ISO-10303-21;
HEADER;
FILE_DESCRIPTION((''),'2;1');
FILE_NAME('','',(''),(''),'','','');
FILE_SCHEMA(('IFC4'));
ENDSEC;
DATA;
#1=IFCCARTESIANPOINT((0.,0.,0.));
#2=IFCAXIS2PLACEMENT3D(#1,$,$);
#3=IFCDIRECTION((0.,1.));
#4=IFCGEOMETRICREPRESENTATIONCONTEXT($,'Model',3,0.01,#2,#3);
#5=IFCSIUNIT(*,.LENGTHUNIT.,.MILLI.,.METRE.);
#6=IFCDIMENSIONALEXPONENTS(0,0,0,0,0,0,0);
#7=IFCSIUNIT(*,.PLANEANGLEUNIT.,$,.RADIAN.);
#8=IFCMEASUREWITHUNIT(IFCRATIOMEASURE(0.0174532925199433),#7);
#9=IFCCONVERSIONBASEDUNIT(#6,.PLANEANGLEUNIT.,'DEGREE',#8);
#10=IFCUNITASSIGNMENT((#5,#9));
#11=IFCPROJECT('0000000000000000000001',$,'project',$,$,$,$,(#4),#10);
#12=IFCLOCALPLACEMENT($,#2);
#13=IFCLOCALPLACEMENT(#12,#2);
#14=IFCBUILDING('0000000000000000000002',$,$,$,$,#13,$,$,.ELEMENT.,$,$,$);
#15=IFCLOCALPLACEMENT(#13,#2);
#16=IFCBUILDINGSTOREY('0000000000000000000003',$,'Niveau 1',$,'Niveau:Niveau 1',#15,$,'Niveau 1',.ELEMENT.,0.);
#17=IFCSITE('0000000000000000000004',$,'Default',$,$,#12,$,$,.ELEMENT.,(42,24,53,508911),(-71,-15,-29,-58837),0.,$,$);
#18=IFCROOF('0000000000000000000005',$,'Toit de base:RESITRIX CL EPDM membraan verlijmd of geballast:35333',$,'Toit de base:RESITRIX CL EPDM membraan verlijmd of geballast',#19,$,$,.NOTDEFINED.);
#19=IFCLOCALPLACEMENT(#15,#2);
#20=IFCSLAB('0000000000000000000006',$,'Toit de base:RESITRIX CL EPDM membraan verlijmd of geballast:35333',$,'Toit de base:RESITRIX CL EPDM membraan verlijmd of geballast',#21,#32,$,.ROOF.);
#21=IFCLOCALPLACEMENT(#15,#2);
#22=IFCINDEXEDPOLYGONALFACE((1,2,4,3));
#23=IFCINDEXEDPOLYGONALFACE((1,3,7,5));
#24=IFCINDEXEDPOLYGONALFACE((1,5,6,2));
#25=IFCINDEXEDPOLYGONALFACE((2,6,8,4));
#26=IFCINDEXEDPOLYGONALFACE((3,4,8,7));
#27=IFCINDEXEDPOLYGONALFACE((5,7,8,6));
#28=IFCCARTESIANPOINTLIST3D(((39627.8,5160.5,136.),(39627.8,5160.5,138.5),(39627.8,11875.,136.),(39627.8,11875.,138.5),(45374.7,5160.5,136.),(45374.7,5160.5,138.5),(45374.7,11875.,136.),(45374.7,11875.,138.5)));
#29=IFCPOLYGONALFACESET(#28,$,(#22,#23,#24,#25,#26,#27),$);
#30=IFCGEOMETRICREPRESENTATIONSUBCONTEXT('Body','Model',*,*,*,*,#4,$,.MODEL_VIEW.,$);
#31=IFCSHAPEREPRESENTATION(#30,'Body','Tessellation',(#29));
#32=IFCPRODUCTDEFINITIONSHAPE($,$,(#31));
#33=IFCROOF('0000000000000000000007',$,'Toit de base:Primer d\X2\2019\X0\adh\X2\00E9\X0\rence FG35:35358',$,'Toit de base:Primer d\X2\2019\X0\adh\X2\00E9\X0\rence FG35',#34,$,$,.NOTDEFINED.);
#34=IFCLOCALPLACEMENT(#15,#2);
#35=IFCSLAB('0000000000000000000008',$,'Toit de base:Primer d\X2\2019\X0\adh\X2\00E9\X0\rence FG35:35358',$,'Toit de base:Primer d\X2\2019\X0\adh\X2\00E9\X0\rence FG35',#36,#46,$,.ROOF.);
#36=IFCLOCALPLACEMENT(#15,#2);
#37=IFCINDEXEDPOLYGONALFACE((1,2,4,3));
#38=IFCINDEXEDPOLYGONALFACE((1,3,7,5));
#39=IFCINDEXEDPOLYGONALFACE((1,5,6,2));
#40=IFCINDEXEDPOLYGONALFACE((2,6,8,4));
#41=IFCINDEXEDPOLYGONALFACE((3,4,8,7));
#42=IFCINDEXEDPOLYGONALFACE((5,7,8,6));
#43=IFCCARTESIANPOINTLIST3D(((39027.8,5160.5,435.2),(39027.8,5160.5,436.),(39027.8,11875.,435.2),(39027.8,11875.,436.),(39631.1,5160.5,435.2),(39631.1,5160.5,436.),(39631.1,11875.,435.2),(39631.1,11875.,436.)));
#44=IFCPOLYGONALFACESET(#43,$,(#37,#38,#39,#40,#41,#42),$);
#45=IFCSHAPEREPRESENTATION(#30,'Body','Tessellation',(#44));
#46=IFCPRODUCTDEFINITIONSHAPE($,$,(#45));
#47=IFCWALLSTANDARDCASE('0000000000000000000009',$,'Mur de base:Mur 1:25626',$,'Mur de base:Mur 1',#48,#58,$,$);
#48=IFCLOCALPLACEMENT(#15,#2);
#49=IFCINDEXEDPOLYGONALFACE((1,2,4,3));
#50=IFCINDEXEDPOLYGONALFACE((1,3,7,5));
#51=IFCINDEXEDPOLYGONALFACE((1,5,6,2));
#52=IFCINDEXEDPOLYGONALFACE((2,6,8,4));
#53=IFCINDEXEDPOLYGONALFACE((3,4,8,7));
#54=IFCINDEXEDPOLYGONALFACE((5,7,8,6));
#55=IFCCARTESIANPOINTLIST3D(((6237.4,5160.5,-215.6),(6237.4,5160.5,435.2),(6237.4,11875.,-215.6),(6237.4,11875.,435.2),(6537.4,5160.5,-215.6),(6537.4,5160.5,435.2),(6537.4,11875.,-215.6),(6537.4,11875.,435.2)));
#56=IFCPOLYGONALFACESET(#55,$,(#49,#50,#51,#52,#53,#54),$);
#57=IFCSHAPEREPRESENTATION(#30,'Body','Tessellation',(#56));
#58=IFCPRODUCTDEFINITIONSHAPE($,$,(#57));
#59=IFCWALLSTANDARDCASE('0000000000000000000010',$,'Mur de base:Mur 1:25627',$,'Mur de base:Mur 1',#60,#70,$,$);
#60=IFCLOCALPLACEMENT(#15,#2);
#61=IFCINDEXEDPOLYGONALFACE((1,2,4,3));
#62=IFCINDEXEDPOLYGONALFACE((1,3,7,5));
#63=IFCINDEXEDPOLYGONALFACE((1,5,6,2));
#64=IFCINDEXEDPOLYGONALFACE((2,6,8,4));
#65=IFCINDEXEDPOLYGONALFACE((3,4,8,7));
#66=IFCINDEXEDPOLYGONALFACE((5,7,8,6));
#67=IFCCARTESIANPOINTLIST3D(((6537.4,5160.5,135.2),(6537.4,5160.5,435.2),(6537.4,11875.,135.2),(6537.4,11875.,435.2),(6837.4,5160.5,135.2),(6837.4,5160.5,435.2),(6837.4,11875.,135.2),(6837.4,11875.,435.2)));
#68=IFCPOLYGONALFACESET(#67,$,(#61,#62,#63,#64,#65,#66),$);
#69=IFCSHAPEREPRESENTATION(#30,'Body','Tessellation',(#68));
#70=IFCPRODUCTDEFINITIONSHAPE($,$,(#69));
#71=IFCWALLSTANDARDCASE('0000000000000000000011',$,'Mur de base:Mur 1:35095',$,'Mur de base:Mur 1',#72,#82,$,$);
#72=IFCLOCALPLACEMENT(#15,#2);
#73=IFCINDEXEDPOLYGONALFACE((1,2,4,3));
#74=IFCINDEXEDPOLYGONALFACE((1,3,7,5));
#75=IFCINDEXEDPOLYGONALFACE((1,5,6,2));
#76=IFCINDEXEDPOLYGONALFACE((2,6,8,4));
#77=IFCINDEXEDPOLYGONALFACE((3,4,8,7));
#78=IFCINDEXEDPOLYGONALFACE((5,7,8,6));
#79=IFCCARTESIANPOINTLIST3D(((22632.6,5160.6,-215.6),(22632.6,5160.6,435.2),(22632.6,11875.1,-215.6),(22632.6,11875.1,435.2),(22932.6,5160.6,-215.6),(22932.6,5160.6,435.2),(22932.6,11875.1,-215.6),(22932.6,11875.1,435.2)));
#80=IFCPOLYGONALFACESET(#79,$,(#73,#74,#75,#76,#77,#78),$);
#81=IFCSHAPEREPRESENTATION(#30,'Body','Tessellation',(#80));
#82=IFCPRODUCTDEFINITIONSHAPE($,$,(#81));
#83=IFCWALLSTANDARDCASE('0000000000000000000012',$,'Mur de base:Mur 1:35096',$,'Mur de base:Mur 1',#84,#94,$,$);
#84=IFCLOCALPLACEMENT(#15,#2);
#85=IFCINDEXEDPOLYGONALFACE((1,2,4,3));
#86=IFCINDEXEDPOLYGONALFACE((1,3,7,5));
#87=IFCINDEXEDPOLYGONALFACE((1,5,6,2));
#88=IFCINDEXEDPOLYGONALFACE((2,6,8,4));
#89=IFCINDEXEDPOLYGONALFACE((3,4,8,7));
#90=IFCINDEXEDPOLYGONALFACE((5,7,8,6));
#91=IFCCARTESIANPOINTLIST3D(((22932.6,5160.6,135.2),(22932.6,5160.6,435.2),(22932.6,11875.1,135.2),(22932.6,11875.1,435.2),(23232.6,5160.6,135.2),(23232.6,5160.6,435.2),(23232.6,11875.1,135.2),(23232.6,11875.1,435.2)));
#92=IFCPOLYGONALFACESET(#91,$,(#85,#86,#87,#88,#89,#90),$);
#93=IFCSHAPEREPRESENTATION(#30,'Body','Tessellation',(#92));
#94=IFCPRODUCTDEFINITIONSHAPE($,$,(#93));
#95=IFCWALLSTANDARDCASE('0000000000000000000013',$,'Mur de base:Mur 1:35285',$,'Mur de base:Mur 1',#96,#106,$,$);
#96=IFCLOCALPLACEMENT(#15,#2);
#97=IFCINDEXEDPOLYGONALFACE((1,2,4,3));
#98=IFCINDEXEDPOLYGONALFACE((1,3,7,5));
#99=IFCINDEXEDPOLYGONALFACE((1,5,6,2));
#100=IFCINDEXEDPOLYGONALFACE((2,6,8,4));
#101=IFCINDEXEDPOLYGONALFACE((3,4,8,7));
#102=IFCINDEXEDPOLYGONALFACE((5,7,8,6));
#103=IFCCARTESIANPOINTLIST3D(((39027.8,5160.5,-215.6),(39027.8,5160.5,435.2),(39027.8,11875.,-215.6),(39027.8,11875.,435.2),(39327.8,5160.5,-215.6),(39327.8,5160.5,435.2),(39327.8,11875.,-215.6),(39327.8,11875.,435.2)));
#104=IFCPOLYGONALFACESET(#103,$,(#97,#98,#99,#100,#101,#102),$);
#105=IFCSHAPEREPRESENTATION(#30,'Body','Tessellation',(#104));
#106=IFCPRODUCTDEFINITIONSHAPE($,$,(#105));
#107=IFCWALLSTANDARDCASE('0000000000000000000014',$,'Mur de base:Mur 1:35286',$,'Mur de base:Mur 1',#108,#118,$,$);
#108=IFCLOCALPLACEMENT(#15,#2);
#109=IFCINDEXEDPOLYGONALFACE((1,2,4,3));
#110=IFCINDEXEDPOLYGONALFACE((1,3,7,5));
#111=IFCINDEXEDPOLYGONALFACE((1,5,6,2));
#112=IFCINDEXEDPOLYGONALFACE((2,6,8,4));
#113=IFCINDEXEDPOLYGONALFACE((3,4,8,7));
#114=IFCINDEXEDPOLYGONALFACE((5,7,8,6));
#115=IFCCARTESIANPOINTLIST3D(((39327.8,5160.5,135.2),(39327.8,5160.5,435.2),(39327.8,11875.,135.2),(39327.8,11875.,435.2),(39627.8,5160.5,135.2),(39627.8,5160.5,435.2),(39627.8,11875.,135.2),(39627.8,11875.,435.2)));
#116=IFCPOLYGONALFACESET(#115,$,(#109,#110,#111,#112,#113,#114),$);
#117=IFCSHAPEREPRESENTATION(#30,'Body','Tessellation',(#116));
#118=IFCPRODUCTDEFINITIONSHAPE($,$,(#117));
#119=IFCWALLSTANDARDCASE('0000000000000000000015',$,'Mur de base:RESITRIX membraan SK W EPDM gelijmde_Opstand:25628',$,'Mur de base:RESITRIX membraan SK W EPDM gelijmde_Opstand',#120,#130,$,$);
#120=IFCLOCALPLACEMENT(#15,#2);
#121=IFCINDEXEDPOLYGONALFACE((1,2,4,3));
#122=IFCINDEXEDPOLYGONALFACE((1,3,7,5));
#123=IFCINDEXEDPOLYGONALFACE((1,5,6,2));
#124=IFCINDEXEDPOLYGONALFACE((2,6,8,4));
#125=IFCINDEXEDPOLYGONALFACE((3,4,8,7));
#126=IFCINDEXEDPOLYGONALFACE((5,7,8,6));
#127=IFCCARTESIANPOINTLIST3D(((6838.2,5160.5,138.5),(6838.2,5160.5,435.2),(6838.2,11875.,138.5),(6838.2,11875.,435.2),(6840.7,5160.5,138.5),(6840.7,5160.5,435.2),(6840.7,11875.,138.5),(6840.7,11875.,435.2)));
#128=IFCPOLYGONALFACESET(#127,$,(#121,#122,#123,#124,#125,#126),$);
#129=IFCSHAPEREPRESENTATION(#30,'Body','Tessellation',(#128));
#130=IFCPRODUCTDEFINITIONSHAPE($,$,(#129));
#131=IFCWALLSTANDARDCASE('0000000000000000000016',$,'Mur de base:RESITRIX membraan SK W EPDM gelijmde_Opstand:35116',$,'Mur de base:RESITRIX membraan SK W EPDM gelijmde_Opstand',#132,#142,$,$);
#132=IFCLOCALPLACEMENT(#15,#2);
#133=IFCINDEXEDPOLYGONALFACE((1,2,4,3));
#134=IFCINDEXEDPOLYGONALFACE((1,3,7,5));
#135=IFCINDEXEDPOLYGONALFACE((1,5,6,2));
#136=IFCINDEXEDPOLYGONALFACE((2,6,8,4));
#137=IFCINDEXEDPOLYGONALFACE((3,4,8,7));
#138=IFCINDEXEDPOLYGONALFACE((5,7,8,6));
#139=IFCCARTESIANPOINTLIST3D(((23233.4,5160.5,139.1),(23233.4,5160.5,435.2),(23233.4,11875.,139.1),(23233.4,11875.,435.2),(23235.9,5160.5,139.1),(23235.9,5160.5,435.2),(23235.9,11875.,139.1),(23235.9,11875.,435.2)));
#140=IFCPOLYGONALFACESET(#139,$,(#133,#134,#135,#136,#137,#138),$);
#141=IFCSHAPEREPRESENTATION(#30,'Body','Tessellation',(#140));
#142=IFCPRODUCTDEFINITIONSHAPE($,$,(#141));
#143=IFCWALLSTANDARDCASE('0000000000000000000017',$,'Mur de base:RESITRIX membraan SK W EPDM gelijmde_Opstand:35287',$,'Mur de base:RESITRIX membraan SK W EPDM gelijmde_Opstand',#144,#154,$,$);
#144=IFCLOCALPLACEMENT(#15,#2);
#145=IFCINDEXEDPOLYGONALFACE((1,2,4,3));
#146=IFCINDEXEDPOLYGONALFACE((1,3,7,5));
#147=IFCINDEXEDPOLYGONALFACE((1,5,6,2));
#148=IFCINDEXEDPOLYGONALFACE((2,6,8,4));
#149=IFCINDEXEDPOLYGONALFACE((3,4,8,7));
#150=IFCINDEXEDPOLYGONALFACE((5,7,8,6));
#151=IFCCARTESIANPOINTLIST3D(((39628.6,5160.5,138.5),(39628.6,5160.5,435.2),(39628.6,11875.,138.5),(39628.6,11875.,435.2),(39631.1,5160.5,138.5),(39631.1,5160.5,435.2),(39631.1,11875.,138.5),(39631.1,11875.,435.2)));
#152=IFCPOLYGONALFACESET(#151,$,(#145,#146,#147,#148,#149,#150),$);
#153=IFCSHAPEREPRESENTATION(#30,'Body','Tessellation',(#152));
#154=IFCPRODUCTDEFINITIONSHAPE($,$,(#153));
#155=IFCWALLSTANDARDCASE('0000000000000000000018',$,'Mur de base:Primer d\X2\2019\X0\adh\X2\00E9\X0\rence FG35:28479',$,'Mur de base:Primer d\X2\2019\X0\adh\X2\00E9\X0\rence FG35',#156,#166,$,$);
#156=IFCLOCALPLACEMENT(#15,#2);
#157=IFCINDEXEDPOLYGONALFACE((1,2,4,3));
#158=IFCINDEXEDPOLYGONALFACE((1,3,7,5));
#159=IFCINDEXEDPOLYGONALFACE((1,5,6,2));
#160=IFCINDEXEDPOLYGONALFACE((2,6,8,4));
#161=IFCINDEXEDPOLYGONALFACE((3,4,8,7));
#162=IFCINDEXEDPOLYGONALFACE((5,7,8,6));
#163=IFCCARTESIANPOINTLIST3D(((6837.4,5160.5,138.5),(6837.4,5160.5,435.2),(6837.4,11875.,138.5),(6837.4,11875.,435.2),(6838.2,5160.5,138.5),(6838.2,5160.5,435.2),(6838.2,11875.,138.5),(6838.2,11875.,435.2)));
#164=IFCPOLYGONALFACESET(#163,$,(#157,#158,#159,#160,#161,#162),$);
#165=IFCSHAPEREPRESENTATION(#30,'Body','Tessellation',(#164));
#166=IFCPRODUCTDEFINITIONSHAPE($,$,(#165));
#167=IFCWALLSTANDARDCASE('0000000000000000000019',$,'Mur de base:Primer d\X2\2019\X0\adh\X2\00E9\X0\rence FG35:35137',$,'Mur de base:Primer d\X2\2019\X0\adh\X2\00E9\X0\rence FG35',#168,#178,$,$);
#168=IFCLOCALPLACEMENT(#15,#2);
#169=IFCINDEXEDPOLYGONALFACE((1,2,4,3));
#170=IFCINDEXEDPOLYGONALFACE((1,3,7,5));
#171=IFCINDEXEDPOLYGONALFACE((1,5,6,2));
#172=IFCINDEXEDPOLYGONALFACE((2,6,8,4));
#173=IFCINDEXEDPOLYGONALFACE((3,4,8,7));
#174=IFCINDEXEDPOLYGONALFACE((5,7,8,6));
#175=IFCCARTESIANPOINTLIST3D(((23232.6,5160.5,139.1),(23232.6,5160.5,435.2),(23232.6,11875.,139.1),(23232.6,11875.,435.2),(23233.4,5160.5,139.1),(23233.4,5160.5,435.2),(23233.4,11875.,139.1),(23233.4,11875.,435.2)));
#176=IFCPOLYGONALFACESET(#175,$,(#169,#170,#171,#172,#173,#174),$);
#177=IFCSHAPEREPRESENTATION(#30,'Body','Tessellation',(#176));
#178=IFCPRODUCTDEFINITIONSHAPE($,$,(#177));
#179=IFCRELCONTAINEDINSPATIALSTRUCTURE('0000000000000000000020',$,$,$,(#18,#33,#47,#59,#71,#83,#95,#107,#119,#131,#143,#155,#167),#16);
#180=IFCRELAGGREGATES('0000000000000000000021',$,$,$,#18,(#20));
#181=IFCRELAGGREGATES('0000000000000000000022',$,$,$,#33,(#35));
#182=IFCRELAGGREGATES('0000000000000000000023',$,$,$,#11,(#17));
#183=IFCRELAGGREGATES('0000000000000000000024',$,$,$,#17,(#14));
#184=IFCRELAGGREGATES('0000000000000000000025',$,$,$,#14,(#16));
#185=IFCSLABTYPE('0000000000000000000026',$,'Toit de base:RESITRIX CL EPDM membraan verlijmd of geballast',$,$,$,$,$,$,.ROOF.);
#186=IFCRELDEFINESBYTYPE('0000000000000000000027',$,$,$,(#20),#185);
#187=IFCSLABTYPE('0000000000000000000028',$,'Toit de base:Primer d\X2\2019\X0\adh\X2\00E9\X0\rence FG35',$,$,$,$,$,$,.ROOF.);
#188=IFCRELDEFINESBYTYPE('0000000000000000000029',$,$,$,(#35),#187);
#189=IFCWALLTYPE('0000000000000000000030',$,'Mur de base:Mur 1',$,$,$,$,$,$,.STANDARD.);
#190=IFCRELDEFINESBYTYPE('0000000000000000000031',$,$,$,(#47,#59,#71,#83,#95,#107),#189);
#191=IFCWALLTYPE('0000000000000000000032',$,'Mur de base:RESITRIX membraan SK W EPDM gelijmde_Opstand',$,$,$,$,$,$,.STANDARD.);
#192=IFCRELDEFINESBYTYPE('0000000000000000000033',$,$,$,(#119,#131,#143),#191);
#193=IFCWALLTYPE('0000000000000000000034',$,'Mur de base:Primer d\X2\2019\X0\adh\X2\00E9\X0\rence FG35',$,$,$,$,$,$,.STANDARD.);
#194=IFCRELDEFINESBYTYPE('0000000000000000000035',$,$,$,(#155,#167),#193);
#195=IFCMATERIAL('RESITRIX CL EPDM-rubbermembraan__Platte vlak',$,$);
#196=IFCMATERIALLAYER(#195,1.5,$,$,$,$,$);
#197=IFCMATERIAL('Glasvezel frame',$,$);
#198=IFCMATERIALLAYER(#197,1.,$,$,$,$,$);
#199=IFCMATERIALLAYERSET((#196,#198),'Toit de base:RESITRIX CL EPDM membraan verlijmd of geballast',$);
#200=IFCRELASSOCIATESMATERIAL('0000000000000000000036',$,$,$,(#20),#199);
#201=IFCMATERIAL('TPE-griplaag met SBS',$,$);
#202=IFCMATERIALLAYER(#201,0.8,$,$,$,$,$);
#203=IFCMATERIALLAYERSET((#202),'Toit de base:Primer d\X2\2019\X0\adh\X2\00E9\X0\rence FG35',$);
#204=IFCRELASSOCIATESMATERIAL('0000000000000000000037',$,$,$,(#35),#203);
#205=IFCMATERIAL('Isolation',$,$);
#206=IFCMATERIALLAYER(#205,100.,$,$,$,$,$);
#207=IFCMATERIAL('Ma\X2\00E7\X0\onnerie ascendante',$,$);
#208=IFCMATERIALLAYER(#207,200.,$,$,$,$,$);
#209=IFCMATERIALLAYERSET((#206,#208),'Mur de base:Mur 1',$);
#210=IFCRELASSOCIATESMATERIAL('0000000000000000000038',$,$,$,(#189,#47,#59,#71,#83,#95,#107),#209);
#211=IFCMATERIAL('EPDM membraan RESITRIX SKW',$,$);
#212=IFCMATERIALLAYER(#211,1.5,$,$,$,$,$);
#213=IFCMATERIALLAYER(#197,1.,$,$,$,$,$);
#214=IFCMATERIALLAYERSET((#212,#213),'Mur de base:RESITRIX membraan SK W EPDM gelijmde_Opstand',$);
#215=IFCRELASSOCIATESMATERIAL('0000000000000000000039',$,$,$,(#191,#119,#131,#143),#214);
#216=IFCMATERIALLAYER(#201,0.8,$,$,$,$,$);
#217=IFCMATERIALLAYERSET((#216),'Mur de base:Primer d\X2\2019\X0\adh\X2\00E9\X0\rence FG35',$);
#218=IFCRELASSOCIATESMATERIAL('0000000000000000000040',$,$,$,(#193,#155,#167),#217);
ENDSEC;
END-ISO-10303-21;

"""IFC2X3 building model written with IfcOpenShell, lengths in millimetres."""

from ifc_helpers import new_model, entity, si_unit, converted_unit, direction, frame, frame_2d, origin, place, context, subcontext, project, spatial, rectangle, extrude, clip, halfspace, material, layer, layer_set, layer_usage, type_object, element, aggregate, save


model = new_model("IFC2X3")

# Units and contexts
model_context = context("Model", 3, precision=0.01, world=origin(), true_north=direction((0.0, 1.0)))
body_context = subcontext(model_context, "Body", "Model", "MODEL_VIEW")
ifc_project = project(units=[si_unit("LENGTHUNIT", "METRE", prefix="MILLI"), converted_unit("PLANEANGLEUNIT", "DEGREE", entity("IfcRatioMeasure", 0.0174532925199433), si_unit("PLANEANGLEUNIT", "RADIAN"), dimensions=[0, 0, 0, 0, 0, 0, 0])], contexts=[model_context])

# Site, building, storey
site_placement = place(None, origin())
site = spatial("IfcSite", under=ifc_project, at=site_placement, Name="Default", CompositionType="ELEMENT", RefLatitude=(42, 24, 53, 508911), RefLongitude=(-71, -15, -29, -58837), RefElevation=0.0)
building_placement = place(site_placement, origin())
building = spatial("IfcBuilding", under=site, at=building_placement, CompositionType="ELEMENT")
storey_placement = place(building_placement, origin())
storey = spatial("IfcBuildingStorey", under=building, at=storey_placement, Name="Niveau 1", ObjectType="Niveau:Niveau 1", LongName="Niveau 1", CompositionType="ELEMENT", Elevation=0.0)

# Roofs, slabs
ifc_material_1 = material(Name="TPE-griplaag met SBS")
ifc_layer_1 = layer(ifc_material_1, 0.8)
ifc_layer_set_1 = layer_set([ifc_layer_1], Name="Toit de base:Primer d’adhérence FG35")
ifc_material_2 = material(Name="Isolation")
ifc_material_3 = material(Name="EPDM membraan RESITRIX SKW")
ifc_material_4 = material(Name="Glasvezel frame")
roof_1_placement = place(storey_placement, frame((39627.8, 5160.5, 136.0)))
roof_1 = element("IfcRoof", 1, at=roof_1_placement, inside=storey, Name="Toit de base:RESITRIX CL EPDM membraan verlijmd of geballast:35333", ObjectType="Toit de base:RESITRIX CL EPDM membraan verlijmd of geballast", ShapeType="NOTDEFINED")
ifc_material_5 = material(Name="RESITRIX CL EPDM-rubbermembraan__Platte vlak")
ifc_layer_2 = layer(ifc_material_5, 1.5)
ifc_layer_3 = layer(ifc_material_4, 1.0)
ifc_layer_set_2 = layer_set([ifc_layer_2, ifc_layer_3], Name="Toit de base:RESITRIX CL EPDM membraan verlijmd of geballast")
slab_type_1 = type_object("IfcSlabType", Name="Toit de base:RESITRIX CL EPDM membraan verlijmd of geballast", PredefinedType="ROOF")
slab_1_placement = place(roof_1_placement, origin())
slab_1 = element("IfcSlab", 2, at=slab_1_placement, type_object=slab_type_1, material=ifc_layer_set_2, Name="Toit de base:RESITRIX CL EPDM membraan verlijmd of geballast:35333", ObjectType="Toit de base:RESITRIX CL EPDM membraan verlijmd of geballast", PredefinedType="ROOF", context=body_context, shape_type="SweptSolid", body=[
    extrude(rectangle(XDim=6714.5, YDim=5747.0, at=frame_2d((0.0, 0.0), x_axis=(0.0, 1.0))), frame((2873.5, 3357.2, 0.0)), (0.0, 0.0, 1.0), 2.5),
])
aggregate(roof_1, [slab_1])
roof_2_placement = place(storey_placement, frame((39027.8, 5160.5, 435.2)))
roof_2 = element("IfcRoof", 3, at=roof_2_placement, inside=storey, Name="Toit de base:Primer d’adhérence FG35:35358", ObjectType="Toit de base:Primer d’adhérence FG35", ShapeType="NOTDEFINED")
slab_type_2 = type_object("IfcSlabType", Name="Toit de base:Primer d’adhérence FG35", PredefinedType="ROOF")
slab_2_placement = place(roof_2_placement, origin())
slab_2 = element("IfcSlab", 4, at=slab_2_placement, type_object=slab_type_2, material=ifc_layer_set_1, Name="Toit de base:Primer d’adhérence FG35:35358", ObjectType="Toit de base:Primer d’adhérence FG35", PredefinedType="ROOF", context=body_context, shape_type="SweptSolid", body=[
    extrude(rectangle(XDim=6714.5, YDim=603.3, at=frame_2d((0.0, 0.0), x_axis=(0.0, 1.0))), frame((301.7, 3357.2, 0.0)), (0.0, 0.0, 1.0), 0.8),
])
aggregate(roof_2, [slab_2])

# Walls
ifc_layer_4 = layer(ifc_material_2, 100.0)
ifc_material_6 = material(Name="Maçonnerie ascendante")
ifc_layer_5 = layer(ifc_material_6, 200.0)
ifc_layer_set_3 = layer_set([ifc_layer_4, ifc_layer_5], Name="Mur de base:Mur 1")
ifc_layer_usage_1 = layer_usage(ifc_layer_set_3, "AXIS2", "NEGATIVE", 150.0)
wall_type_1 = type_object("IfcWallType", Name="Mur de base:Mur 1", PredefinedType="STANDARD", material=ifc_layer_set_3)
wall_1_placement = place(storey_placement, frame((6387.4, 11875.0, -215.6), z_axis=(0.0, 0.0, 1.0), x_axis=(0.0, -1.0, 0.0)))
element("IfcWallStandardCase", 5, at=wall_1_placement, inside=storey, type_object=wall_type_1, material=ifc_layer_usage_1, Name="Mur de base:Mur 1:25626", ObjectType="Mur de base:Mur 1", context=body_context, shape_type="SweptSolid", body=[
    extrude(rectangle(XDim=6714.5, YDim=300.0, at=frame_2d((3357.2, 0.0), x_axis=(-1.0, 0.0))), origin(), (0.0, 0.0, 1.0), 650.8),
])
ifc_layer_usage_2 = layer_usage(ifc_layer_set_3, "AXIS2", "NEGATIVE", 150.0)
wall_2_placement = place(storey_placement, frame((6687.4, 11875.0, 135.2), z_axis=(0.0, 0.0, 1.0), x_axis=(0.0, -1.0, 0.0)))
element("IfcWallStandardCase", 6, at=wall_2_placement, inside=storey, type_object=wall_type_1, material=ifc_layer_usage_2, Name="Mur de base:Mur 1:25627", ObjectType="Mur de base:Mur 1", context=body_context, shape_type="Clipping", body=[
    clip(extrude(rectangle(XDim=6714.5, YDim=300.0, at=frame_2d((3357.2, 0.0), x_axis=(-1.0, 0.0))), origin(), (0.0, 0.0, 1.0), 300.0), halfspace(frame((6714.5, -150.0, 0.0), z_axis=(0.0, 0.0, -1.0), x_axis=(0.0, 1.0, 0.0)), False)),
])
ifc_layer_usage_3 = layer_usage(ifc_layer_set_3, "AXIS2", "NEGATIVE", 150.0)
wall_3_placement = place(storey_placement, frame((22782.6, 11875.1, -215.6), z_axis=(0.0, 0.0, 1.0), x_axis=(0.0, -1.0, 0.0)))
element("IfcWallStandardCase", 7, at=wall_3_placement, inside=storey, type_object=wall_type_1, material=ifc_layer_usage_3, Name="Mur de base:Mur 1:35095", ObjectType="Mur de base:Mur 1", context=body_context, shape_type="SweptSolid", body=[
    extrude(rectangle(XDim=6714.5, YDim=300.0, at=frame_2d((3357.2, 0.0), x_axis=(-1.0, 0.0))), origin(), (0.0, 0.0, 1.0), 650.8),
])
ifc_layer_usage_4 = layer_usage(ifc_layer_set_3, "AXIS2", "NEGATIVE", 150.0)
wall_4_placement = place(storey_placement, frame((23082.6, 11875.1, 135.2), z_axis=(0.0, 0.0, 1.0), x_axis=(0.0, -1.0, 0.0)))
element("IfcWallStandardCase", 8, at=wall_4_placement, inside=storey, type_object=wall_type_1, material=ifc_layer_usage_4, Name="Mur de base:Mur 1:35096", ObjectType="Mur de base:Mur 1", context=body_context, shape_type="Clipping", body=[
    clip(extrude(rectangle(XDim=6714.5, YDim=300.0, at=frame_2d((3357.2, 0.0), x_axis=(-1.0, 0.0))), origin(), (0.0, 0.0, 1.0), 300.0), halfspace(frame((6714.5, -150.0, 0.0), z_axis=(0.0, 0.0, -1.0), x_axis=(0.0, 1.0, 0.0)), False)),
])
ifc_layer_usage_5 = layer_usage(ifc_layer_set_3, "AXIS2", "NEGATIVE", 150.0)
wall_5_placement = place(storey_placement, frame((39177.8, 11875.0, -215.6), z_axis=(0.0, 0.0, 1.0), x_axis=(0.0, -1.0, 0.0)))
element("IfcWallStandardCase", 9, at=wall_5_placement, inside=storey, type_object=wall_type_1, material=ifc_layer_usage_5, Name="Mur de base:Mur 1:35285", ObjectType="Mur de base:Mur 1", context=body_context, shape_type="SweptSolid", body=[
    extrude(rectangle(XDim=6714.5, YDim=300.0, at=frame_2d((3357.2, 0.0), x_axis=(-1.0, 0.0))), origin(), (0.0, 0.0, 1.0), 650.8),
])
ifc_layer_usage_6 = layer_usage(ifc_layer_set_3, "AXIS2", "NEGATIVE", 150.0)
wall_6_placement = place(storey_placement, frame((39477.8, 11875.0, 135.2), z_axis=(0.0, 0.0, 1.0), x_axis=(0.0, -1.0, 0.0)))
element("IfcWallStandardCase", 10, at=wall_6_placement, inside=storey, type_object=wall_type_1, material=ifc_layer_usage_6, Name="Mur de base:Mur 1:35286", ObjectType="Mur de base:Mur 1", context=body_context, shape_type="Clipping", body=[
    clip(extrude(rectangle(XDim=6714.5, YDim=300.0, at=frame_2d((3357.2, 0.0), x_axis=(-1.0, 0.0))), origin(), (0.0, 0.0, 1.0), 300.0), halfspace(frame((6714.5, -150.0, 0.0), z_axis=(0.0, 0.0, -1.0), x_axis=(0.0, 1.0, 0.0)), False)),
])
ifc_layer_6 = layer(ifc_material_3, 1.5)
ifc_layer_7 = layer(ifc_material_4, 1.0)
ifc_layer_set_4 = layer_set([ifc_layer_6, ifc_layer_7], Name="Mur de base:RESITRIX membraan SK W EPDM gelijmde_Opstand")
ifc_layer_usage_7 = layer_usage(ifc_layer_set_4, "AXIS2", "NEGATIVE", 1.2)
wall_type_2 = type_object("IfcWallType", Name="Mur de base:RESITRIX membraan SK W EPDM gelijmde_Opstand", PredefinedType="STANDARD", material=ifc_layer_set_4)
wall_7_placement = place(storey_placement, frame((6839.4, 11875.0, 138.5), z_axis=(0.0, 0.0, 1.0), x_axis=(0.0, -1.0, 0.0)))
element("IfcWallStandardCase", 11, at=wall_7_placement, inside=storey, type_object=wall_type_2, material=ifc_layer_usage_7, Name="Mur de base:RESITRIX membraan SK W EPDM gelijmde_Opstand:25628", ObjectType="Mur de base:RESITRIX membraan SK W EPDM gelijmde_Opstand", context=body_context, shape_type="SweptSolid", body=[
    extrude(rectangle(XDim=6714.5, YDim=2.5, at=frame_2d((3357.2, 0.0), x_axis=(-1.0, 0.0))), origin(), (0.0, 0.0, 1.0), 296.7),
])
ifc_layer_usage_8 = layer_usage(ifc_layer_set_4, "AXIS2", "NEGATIVE", 1.2)
wall_8_placement = place(storey_placement, frame((23234.6, 11875.0, 139.1), z_axis=(0.0, 0.0, 1.0), x_axis=(0.0, -1.0, 0.0)))
element("IfcWallStandardCase", 12, at=wall_8_placement, inside=storey, type_object=wall_type_2, material=ifc_layer_usage_8, Name="Mur de base:RESITRIX membraan SK W EPDM gelijmde_Opstand:35116", ObjectType="Mur de base:RESITRIX membraan SK W EPDM gelijmde_Opstand", context=body_context, shape_type="SweptSolid", body=[
    extrude(rectangle(XDim=6714.5, YDim=2.5, at=frame_2d((3357.2, 0.0), x_axis=(-1.0, 0.0))), origin(), (0.0, 0.0, 1.0), 296.1),
])
ifc_layer_usage_9 = layer_usage(ifc_layer_set_4, "AXIS2", "NEGATIVE", 1.2)
wall_9_placement = place(storey_placement, frame((39629.8, 11875.0, 138.5), z_axis=(0.0, 0.0, 1.0), x_axis=(0.0, -1.0, 0.0)))
element("IfcWallStandardCase", 13, at=wall_9_placement, inside=storey, type_object=wall_type_2, material=ifc_layer_usage_9, Name="Mur de base:RESITRIX membraan SK W EPDM gelijmde_Opstand:35287", ObjectType="Mur de base:RESITRIX membraan SK W EPDM gelijmde_Opstand", context=body_context, shape_type="SweptSolid", body=[
    extrude(rectangle(XDim=6714.5, YDim=2.5, at=frame_2d((3357.2, 0.0), x_axis=(-1.0, 0.0))), origin(), (0.0, 0.0, 1.0), 296.7),
])
ifc_layer_8 = layer(ifc_material_1, 0.8)
ifc_layer_set_5 = layer_set([ifc_layer_8], Name="Mur de base:Primer d’adhérence FG35")
ifc_layer_usage_10 = layer_usage(ifc_layer_set_5, "AXIS2", "NEGATIVE", 0.4)
wall_type_3 = type_object("IfcWallType", Name="Mur de base:Primer d’adhérence FG35", PredefinedType="STANDARD", material=ifc_layer_set_5)
wall_10_placement = place(storey_placement, frame((6837.8, 11875.0, 138.5), z_axis=(0.0, 0.0, 1.0), x_axis=(0.0, -1.0, 0.0)))
element("IfcWallStandardCase", 14, at=wall_10_placement, inside=storey, type_object=wall_type_3, material=ifc_layer_usage_10, Name="Mur de base:Primer d’adhérence FG35:28479", ObjectType="Mur de base:Primer d’adhérence FG35", context=body_context, shape_type="SweptSolid", body=[
    extrude(rectangle(XDim=6714.5, YDim=0.8, at=frame_2d((3357.2, 0.0), x_axis=(-1.0, 0.0))), origin(), (0.0, 0.0, 1.0), 296.7),
])
ifc_layer_usage_11 = layer_usage(ifc_layer_set_5, "AXIS2", "NEGATIVE", 0.4)
wall_11_placement = place(storey_placement, frame((23233.0, 11875.0, 139.1), z_axis=(0.0, 0.0, 1.0), x_axis=(0.0, -1.0, 0.0)))
element("IfcWallStandardCase", 15, at=wall_11_placement, inside=storey, type_object=wall_type_3, material=ifc_layer_usage_11, Name="Mur de base:Primer d’adhérence FG35:35137", ObjectType="Mur de base:Primer d’adhérence FG35", context=body_context, shape_type="SweptSolid", body=[
    extrude(rectangle(XDim=6714.5, YDim=0.8, at=frame_2d((3357.2, 0.0), x_axis=(-1.0, 0.0))), origin(), (0.0, 0.0, 1.0), 296.1),
])

save(model, "model.ifc")
